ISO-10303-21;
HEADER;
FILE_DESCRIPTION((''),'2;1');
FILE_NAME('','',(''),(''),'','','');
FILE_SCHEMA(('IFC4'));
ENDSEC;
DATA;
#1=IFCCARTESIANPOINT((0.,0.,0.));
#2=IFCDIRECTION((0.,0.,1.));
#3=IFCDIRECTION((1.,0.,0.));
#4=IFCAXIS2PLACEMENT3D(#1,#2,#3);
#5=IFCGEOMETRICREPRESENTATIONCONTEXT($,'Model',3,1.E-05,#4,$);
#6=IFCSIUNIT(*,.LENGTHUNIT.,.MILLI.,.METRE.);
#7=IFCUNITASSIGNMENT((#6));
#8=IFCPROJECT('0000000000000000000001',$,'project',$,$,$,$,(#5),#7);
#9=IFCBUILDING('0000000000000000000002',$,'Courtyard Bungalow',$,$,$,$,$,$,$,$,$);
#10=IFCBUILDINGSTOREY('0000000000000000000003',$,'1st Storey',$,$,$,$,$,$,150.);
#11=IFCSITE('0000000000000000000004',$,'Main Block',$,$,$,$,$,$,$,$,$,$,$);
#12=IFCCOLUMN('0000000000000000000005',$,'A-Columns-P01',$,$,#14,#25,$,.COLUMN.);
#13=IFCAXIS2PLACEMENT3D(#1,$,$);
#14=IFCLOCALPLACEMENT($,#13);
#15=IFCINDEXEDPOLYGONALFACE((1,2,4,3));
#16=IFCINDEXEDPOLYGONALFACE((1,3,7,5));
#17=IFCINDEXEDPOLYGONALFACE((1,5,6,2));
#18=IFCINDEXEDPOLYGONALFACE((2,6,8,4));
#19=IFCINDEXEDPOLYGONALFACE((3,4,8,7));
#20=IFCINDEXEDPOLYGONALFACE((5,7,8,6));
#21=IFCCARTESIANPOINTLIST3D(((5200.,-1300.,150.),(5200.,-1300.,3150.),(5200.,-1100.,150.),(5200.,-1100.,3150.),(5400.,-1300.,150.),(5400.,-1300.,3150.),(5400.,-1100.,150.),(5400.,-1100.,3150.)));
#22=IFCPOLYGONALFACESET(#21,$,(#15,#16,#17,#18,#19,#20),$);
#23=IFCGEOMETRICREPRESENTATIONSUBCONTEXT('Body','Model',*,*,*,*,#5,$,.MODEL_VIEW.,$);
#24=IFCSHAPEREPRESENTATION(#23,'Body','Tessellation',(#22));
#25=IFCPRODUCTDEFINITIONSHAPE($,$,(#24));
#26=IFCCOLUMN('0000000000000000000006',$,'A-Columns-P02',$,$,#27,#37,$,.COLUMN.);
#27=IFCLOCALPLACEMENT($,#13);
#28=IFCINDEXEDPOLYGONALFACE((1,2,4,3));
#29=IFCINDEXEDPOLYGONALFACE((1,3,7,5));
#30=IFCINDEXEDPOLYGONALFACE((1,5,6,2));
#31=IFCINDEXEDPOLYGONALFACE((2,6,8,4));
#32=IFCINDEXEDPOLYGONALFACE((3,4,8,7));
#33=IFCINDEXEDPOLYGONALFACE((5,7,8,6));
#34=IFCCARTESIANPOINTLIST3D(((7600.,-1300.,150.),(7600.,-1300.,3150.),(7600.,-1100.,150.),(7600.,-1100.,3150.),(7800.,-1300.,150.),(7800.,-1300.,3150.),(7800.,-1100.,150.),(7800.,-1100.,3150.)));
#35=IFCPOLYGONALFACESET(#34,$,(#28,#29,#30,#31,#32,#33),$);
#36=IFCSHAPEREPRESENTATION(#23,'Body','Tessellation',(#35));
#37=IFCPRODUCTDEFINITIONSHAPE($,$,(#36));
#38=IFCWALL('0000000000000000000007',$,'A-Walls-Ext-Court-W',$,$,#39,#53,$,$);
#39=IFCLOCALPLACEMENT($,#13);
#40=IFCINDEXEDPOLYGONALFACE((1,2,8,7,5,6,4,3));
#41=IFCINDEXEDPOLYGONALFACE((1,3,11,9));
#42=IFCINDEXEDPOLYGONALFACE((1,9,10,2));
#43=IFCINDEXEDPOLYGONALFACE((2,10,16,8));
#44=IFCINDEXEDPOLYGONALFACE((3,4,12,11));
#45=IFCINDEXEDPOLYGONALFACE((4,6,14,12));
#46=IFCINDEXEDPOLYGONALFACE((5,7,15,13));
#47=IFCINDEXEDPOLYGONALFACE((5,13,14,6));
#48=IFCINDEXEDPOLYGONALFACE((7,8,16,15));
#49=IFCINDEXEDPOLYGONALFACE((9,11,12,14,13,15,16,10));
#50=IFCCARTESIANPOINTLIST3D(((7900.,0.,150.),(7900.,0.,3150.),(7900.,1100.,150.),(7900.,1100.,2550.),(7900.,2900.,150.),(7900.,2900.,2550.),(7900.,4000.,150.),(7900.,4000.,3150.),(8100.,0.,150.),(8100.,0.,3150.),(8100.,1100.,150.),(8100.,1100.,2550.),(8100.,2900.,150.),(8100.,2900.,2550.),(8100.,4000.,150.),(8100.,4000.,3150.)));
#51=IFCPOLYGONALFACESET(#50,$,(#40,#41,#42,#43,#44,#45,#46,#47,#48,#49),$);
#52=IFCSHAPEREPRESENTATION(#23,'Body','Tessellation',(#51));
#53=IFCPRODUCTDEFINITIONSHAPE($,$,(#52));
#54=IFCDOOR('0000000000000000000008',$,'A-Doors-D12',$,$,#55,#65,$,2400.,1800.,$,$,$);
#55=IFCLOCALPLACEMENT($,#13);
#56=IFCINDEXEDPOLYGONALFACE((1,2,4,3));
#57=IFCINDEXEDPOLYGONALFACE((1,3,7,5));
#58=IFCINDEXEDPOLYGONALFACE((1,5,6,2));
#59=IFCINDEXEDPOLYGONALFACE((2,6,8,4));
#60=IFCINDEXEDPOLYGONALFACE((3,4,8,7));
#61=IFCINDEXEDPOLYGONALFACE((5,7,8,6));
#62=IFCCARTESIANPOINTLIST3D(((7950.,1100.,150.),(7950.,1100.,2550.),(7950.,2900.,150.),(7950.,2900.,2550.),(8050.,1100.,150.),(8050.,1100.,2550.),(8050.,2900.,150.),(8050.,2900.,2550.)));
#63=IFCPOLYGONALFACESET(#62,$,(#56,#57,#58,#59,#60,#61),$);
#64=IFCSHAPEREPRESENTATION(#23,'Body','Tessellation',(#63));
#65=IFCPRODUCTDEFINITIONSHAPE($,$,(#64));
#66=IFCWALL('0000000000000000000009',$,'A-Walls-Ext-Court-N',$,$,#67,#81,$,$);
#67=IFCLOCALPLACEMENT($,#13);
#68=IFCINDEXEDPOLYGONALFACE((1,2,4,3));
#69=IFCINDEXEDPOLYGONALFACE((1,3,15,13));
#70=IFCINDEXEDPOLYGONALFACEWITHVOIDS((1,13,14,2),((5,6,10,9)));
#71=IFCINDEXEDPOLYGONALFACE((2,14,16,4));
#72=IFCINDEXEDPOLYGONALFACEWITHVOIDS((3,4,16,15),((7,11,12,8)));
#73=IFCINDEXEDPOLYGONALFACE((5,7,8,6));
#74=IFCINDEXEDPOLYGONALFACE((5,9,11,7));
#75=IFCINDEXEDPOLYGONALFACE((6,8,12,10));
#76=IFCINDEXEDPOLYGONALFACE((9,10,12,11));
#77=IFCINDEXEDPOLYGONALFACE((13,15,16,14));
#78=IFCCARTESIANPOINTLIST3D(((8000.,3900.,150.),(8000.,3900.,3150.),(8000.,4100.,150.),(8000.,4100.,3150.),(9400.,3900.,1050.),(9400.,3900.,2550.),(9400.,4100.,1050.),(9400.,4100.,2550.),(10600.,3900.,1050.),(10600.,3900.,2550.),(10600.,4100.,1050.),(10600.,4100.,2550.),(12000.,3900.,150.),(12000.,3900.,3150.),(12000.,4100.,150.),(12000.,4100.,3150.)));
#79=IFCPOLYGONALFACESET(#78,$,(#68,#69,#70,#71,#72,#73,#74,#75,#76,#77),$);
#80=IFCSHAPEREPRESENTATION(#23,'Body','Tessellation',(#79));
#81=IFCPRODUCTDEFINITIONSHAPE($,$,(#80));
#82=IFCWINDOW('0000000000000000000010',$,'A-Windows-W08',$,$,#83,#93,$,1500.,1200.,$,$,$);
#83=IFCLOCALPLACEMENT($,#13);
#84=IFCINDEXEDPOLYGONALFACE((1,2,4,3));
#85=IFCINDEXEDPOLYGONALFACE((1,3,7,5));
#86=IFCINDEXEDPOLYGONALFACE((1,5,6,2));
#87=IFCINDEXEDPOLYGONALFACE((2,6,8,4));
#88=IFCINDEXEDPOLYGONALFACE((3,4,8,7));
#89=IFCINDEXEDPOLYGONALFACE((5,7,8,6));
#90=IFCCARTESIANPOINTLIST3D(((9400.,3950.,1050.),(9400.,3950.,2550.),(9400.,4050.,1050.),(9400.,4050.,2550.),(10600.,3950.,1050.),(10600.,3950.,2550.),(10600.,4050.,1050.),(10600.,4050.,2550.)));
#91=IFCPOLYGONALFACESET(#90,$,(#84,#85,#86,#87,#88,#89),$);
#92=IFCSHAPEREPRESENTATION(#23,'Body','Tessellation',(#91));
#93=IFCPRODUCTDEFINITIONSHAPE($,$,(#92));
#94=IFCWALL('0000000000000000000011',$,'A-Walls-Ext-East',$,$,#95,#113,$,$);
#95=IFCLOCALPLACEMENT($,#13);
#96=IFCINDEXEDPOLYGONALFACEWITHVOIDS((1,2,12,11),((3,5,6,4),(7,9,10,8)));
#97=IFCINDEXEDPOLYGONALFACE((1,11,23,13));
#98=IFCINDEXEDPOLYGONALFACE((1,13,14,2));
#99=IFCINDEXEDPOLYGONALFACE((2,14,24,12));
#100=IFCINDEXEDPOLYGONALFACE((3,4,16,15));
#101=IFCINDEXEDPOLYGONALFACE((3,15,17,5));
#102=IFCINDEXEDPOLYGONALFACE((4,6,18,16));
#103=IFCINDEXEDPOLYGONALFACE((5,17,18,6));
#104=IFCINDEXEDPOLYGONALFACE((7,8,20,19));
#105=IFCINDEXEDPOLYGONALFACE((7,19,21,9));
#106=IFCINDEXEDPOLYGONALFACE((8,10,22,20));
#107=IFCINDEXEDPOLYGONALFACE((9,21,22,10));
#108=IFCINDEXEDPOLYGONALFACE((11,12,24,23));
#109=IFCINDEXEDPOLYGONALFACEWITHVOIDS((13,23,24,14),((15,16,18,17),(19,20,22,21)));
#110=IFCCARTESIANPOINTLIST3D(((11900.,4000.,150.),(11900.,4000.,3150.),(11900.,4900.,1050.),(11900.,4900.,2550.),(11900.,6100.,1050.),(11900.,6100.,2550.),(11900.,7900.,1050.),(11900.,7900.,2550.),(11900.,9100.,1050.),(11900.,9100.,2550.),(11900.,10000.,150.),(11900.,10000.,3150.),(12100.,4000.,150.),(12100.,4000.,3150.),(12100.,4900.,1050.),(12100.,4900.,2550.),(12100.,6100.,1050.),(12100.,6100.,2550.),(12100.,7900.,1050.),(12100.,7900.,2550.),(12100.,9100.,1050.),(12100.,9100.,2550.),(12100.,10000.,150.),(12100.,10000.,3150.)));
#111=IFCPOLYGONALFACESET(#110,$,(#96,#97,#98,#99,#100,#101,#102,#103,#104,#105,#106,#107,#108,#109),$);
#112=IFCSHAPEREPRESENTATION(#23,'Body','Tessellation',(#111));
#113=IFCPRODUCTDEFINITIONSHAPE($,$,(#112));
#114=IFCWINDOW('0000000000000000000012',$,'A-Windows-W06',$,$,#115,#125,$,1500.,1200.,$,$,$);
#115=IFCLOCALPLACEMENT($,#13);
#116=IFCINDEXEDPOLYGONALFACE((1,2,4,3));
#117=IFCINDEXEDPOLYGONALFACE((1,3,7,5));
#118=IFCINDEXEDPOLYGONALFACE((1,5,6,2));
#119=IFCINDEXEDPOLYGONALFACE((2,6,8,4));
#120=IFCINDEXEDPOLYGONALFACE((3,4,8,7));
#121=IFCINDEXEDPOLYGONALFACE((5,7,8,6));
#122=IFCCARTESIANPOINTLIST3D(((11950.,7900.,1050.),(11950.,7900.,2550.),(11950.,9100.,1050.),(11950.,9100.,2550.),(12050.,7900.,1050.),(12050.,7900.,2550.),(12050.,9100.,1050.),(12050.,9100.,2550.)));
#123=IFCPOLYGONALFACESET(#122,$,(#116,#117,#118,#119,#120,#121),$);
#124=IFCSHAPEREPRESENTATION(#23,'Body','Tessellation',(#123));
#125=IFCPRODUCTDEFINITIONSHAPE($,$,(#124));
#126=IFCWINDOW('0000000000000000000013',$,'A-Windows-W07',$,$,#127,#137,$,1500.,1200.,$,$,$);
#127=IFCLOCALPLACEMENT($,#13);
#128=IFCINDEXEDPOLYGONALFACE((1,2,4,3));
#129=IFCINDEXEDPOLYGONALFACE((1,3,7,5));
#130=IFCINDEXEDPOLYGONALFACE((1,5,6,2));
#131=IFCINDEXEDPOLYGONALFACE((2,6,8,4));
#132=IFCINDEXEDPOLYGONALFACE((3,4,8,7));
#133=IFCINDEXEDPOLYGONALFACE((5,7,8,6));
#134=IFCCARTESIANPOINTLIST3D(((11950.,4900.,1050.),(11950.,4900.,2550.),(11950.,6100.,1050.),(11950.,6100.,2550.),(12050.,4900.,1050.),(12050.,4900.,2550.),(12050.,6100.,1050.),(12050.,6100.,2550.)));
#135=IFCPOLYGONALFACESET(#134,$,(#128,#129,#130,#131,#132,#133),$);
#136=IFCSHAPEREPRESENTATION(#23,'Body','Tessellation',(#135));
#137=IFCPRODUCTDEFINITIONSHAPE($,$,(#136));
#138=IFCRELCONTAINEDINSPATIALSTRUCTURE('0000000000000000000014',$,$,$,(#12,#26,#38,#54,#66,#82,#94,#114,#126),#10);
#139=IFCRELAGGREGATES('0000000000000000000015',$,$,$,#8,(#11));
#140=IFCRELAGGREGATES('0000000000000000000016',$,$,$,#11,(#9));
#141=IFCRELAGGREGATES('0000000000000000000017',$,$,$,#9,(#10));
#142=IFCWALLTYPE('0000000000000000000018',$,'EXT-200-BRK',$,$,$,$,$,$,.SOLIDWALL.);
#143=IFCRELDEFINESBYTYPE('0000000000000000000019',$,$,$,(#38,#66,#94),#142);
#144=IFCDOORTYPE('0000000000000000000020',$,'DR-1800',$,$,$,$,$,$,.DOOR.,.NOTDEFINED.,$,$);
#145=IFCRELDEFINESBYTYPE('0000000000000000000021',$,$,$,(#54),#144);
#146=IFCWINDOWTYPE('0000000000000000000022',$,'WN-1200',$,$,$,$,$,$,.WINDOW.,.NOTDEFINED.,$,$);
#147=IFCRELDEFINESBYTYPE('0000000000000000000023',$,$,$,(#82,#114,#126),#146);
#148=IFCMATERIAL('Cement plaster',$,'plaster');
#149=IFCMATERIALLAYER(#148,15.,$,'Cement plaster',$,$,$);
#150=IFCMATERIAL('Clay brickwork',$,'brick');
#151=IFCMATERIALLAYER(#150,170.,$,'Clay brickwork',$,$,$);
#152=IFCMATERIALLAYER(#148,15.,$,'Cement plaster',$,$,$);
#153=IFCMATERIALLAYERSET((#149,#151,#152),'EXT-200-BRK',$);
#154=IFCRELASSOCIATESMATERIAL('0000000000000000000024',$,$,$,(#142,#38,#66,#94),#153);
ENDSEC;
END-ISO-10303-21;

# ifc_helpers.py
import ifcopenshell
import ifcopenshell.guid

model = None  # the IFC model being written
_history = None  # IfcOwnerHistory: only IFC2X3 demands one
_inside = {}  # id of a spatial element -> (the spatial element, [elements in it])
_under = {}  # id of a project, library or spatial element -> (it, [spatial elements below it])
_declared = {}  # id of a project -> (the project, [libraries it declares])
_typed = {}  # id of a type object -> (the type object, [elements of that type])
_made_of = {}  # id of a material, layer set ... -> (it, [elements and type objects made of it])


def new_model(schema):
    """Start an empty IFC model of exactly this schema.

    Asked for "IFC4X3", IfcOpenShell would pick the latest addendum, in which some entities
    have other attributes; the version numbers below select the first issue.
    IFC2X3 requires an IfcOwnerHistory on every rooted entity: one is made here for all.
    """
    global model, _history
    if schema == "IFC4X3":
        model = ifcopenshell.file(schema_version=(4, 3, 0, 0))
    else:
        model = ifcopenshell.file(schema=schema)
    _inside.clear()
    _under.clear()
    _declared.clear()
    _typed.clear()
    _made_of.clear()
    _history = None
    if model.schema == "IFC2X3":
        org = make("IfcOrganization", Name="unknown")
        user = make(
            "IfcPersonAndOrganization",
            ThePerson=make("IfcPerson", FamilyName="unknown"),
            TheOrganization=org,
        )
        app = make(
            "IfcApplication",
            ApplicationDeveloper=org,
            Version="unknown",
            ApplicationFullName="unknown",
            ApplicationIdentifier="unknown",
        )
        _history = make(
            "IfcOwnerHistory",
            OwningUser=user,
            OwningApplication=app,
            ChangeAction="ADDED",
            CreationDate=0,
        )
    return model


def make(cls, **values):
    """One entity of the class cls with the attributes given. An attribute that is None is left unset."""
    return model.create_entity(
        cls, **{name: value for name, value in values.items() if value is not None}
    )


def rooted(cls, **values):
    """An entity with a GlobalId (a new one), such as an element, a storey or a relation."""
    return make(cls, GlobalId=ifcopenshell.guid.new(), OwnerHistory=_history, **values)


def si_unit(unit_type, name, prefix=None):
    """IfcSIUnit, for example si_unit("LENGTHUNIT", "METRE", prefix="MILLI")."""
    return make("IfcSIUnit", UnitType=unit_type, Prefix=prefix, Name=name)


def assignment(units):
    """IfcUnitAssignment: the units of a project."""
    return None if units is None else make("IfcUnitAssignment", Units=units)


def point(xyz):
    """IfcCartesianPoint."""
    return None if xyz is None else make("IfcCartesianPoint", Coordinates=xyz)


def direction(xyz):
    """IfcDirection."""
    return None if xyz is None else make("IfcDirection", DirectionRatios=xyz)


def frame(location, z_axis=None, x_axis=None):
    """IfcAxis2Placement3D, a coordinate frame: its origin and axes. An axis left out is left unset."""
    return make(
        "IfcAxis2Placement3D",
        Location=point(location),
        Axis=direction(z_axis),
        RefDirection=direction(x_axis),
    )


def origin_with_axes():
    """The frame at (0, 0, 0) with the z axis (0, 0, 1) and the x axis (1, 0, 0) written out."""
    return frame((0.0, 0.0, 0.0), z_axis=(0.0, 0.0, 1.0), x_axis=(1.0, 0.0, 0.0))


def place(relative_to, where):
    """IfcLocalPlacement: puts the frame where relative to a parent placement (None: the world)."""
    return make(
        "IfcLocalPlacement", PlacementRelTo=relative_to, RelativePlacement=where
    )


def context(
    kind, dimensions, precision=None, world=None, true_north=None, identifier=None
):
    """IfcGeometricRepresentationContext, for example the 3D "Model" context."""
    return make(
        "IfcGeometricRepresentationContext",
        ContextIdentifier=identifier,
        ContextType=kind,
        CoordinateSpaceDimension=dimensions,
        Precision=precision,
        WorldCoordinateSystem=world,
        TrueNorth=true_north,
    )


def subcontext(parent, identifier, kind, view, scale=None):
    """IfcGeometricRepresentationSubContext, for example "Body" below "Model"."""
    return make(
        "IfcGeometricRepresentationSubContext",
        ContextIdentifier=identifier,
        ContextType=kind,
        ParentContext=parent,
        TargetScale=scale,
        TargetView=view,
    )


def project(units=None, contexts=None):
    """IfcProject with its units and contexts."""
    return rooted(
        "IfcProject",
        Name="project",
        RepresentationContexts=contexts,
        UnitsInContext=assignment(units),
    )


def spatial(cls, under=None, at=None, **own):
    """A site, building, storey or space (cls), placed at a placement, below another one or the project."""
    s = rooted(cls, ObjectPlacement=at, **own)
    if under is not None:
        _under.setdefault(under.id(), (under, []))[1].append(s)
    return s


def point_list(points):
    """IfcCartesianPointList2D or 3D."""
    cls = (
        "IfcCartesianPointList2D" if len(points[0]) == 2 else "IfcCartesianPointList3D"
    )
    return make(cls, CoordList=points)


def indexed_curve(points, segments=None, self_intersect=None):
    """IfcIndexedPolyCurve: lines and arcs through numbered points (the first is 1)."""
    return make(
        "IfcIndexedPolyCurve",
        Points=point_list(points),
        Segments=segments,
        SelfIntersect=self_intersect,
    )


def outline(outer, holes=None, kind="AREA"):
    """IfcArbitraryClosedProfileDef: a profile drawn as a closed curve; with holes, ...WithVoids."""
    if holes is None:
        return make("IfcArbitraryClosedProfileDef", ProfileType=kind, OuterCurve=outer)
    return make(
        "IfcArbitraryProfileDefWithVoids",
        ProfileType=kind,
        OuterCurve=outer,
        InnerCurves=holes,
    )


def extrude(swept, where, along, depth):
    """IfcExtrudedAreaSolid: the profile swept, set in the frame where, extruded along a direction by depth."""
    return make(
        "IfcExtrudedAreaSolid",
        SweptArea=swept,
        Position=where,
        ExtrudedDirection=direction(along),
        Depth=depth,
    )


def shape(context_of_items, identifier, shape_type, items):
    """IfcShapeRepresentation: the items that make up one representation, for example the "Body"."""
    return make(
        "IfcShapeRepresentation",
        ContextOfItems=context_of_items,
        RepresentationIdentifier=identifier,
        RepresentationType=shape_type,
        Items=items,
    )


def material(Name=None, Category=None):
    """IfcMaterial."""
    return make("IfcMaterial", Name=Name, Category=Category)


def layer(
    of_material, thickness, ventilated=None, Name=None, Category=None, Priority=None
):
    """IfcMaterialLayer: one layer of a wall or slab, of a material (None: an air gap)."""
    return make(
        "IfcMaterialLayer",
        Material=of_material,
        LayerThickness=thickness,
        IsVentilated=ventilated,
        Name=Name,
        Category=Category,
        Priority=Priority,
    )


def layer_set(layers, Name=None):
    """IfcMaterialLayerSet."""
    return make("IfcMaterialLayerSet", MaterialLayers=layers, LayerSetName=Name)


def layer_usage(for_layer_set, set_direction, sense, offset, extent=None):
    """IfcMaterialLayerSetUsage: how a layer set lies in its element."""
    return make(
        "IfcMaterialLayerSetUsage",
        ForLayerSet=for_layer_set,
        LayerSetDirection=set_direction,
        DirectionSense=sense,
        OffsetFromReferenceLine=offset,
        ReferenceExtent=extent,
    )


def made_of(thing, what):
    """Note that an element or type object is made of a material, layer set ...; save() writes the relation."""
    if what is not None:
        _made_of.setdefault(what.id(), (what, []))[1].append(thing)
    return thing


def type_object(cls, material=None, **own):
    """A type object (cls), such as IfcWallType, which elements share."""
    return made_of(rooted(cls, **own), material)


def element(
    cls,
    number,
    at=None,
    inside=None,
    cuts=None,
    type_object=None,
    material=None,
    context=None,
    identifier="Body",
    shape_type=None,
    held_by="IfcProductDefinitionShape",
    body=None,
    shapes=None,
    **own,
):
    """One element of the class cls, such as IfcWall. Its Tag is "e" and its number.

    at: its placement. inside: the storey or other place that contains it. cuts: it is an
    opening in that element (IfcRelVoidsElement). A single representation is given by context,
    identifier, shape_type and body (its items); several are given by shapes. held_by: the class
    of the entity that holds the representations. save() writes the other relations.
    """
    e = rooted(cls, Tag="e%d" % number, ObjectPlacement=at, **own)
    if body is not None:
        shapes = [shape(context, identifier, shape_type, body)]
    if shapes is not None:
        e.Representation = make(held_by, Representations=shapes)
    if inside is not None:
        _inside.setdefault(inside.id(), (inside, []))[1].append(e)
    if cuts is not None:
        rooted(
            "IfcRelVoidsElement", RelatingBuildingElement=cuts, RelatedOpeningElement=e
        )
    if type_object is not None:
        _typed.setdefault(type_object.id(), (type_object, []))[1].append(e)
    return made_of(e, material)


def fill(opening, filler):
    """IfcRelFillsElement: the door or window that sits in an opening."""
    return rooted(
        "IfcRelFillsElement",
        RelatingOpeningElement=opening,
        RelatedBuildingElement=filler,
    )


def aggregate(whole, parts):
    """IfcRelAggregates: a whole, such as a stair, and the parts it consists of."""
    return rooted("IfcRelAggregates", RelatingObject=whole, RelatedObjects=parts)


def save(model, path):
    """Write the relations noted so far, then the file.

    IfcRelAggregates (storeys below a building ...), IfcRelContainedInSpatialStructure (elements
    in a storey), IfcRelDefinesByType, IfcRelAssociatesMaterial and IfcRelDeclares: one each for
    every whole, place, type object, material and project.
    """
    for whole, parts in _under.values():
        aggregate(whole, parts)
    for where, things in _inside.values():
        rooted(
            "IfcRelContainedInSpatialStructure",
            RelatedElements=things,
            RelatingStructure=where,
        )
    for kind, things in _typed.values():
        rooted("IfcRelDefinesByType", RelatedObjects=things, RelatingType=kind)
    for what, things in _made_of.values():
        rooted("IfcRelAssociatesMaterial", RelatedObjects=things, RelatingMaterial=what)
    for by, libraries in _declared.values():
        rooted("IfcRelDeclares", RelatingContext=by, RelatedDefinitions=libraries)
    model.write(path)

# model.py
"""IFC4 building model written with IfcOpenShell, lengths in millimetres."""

from ifc_helpers import new_model, si_unit, frame, origin_with_axes, place, context, subcontext, project, spatial, indexed_curve, outline, extrude, material, layer, layer_set, layer_usage, type_object, element, fill, save


model = new_model("IFC4")

# Units and contexts
model_context = context("Model", 3, precision=1e-05, world=origin_with_axes())
body_context = subcontext(model_context, "Body", "Model", "MODEL_VIEW")
ifc_project = project(units=[si_unit("LENGTHUNIT", "METRE", prefix="MILLI")], contexts=[model_context])

# Site, building, storey
site = spatial("IfcSite", under=ifc_project, Name="Main Block")
building = spatial("IfcBuilding", under=site, Name="Courtyard Bungalow")
storey = spatial("IfcBuildingStorey", under=building, Name="1st Storey", Elevation=150.0)

# Columns
for number, where, z_axis, x_axis, name in (
    (1, (5300.0, -1200.0, 150.0), (0.0, 0.0, 1.0), (1.0, 0.0, 0.0), "A-Columns-P01"),
    (2, (7700.0, -1200.0, 150.0), (0.0, 0.0, 1.0), (1.0, 0.0, 0.0), "A-Columns-P02"),
):
    element("IfcColumn", number, at=place(None, frame(where, z_axis=z_axis, x_axis=x_axis)), inside=storey, Name=name, PredefinedType="COLUMN", context=body_context, shape_type="SweptSolid", body=[
        extrude(outline(indexed_curve([(-100.0, -100.0), (100.0, -100.0), (100.0, 100.0), (-100.0, 100.0)])), None, (0.0, 0.0, 1.0), 3000.0),
    ])

# Wall, opening, door
ifc_material_1 = material(Name="Cement plaster", Category="plaster")
ifc_layer_1 = layer(ifc_material_1, 15.0, Name="Cement plaster")
ifc_material_2 = material(Name="Clay brickwork", Category="brick")
ifc_layer_2 = layer(ifc_material_2, 170.0, Name="Clay brickwork")
ifc_layer_3 = layer(ifc_material_1, 15.0, Name="Cement plaster")
ifc_layer_set_1 = layer_set([ifc_layer_1, ifc_layer_2, ifc_layer_3], Name="EXT-200-BRK")
ifc_layer_usage_1 = layer_usage(ifc_layer_set_1, "AXIS2", "POSITIVE", 0.0)
wall_type_1 = type_object("IfcWallType", Name="EXT-200-BRK", PredefinedType="SOLIDWALL", material=ifc_layer_set_1)
wall_1_placement = place(None, frame((8100.0, 0.0, 150.0), z_axis=(0.0, 0.0, 1.0), x_axis=(0.0, 1.0, 0.0)))
wall_1 = element("IfcWall", 3, at=wall_1_placement, inside=storey, type_object=wall_type_1, material=ifc_layer_usage_1, Name="A-Walls-Ext-Court-W", context=body_context, shape_type="SweptSolid", body=[
    extrude(outline(indexed_curve([(0.0, 0.0), (0.0, 200.0), (4000.0, 200.0), (4000.0, 0.0), (0.0, 0.0)], self_intersect=False)), origin_with_axes(), (0.0, 0.0, 1.0), 3000.0),
])
opening_1_placement = place(wall_1_placement, frame((2000.0, 100.0, 0.0), z_axis=(0.0, 0.0, 1.0), x_axis=(1.0, 0.0, 0.0)))
opening_1 = element("IfcOpeningElement", 4, at=opening_1_placement, cuts=wall_1, PredefinedType="OPENING", context=body_context, shape_type="SweptSolid", body=[
    extrude(outline(indexed_curve([(-900.0, -150.0), (900.0, -150.0), (900.0, 150.0), (-900.0, 150.0)])), None, (0.0, 0.0, 1.0), 2400.0),
])
door_type_1 = type_object("IfcDoorType", Name="DR-1800", OperationType="NOTDEFINED", PredefinedType="DOOR")
door_1_placement = place(None, frame((8000.0, 2000.0, 150.0), z_axis=(0.0, 0.0, 1.0), x_axis=(0.0, 1.0, 0.0)))
door_1 = element("IfcDoor", 5, at=door_1_placement, inside=storey, type_object=door_type_1, Name="A-Doors-D12", OverallHeight=2400.0, OverallWidth=1800.0, context=body_context, shape_type="SweptSolid", body=[
    extrude(outline(indexed_curve([(-900.0, -50.0), (900.0, -50.0), (900.0, 50.0), (-900.0, 50.0)])), None, (0.0, 0.0, 1.0), 2400.0),
])
fill(opening_1, door_1)

# Wall, opening, window
ifc_layer_usage_2 = layer_usage(ifc_layer_set_1, "AXIS2", "POSITIVE", 0.0)
wall_2_placement = place(None, frame((8000.0, 3900.0, 150.0), z_axis=(0.0, 0.0, 1.0), x_axis=(1.0, 0.0, 0.0)))
wall_2 = element("IfcWall", 6, at=wall_2_placement, inside=storey, type_object=wall_type_1, material=ifc_layer_usage_2, Name="A-Walls-Ext-Court-N", context=body_context, shape_type="SweptSolid", body=[
    extrude(outline(indexed_curve([(0.0, 0.0), (0.0, 200.0), (4000.0, 200.0), (4000.0, 0.0), (0.0, 0.0)], self_intersect=False)), origin_with_axes(), (0.0, 0.0, 1.0), 3000.0),
])
opening_2_placement = place(wall_2_placement, frame((2000.0, 100.0, 900.0), z_axis=(0.0, 0.0, 1.0), x_axis=(1.0, 0.0, 0.0)))
opening_2 = element("IfcOpeningElement", 7, at=opening_2_placement, cuts=wall_2, PredefinedType="OPENING", context=body_context, shape_type="SweptSolid", body=[
    extrude(outline(indexed_curve([(-600.0, -150.0), (600.0, -150.0), (600.0, 150.0), (-600.0, 150.0)])), None, (0.0, 0.0, 1.0), 1500.0),
])
window_type_1 = type_object("IfcWindowType", Name="WN-1200", PartitioningType="NOTDEFINED", PredefinedType="WINDOW")
window_1_placement = place(None, frame((10000.0, 4000.0, 1050.0), z_axis=(0.0, 0.0, 1.0), x_axis=(1.0, 0.0, 0.0)))
window_1 = element("IfcWindow", 8, at=window_1_placement, inside=storey, type_object=window_type_1, Name="A-Windows-W08", OverallHeight=1500.0, OverallWidth=1200.0, context=body_context, shape_type="SweptSolid", body=[
    extrude(outline(indexed_curve([(-600.0, -50.0), (600.0, -50.0), (600.0, 50.0), (-600.0, 50.0)])), None, (0.0, 0.0, 1.0), 1500.0),
])
fill(opening_2, window_1)

# Wall, openings, windows
ifc_layer_usage_3 = layer_usage(ifc_layer_set_1, "AXIS2", "POSITIVE", 0.0)
wall_3_placement = place(None, frame((12100.0, 4000.0, 150.0), z_axis=(0.0, 0.0, 1.0), x_axis=(0.0, 1.0, 0.0)))
wall_3 = element("IfcWall", 9, at=wall_3_placement, inside=storey, type_object=wall_type_1, material=ifc_layer_usage_3, Name="A-Walls-Ext-East", context=body_context, shape_type="SweptSolid", body=[
    extrude(outline(indexed_curve([(0.0, 0.0), (0.0, 200.0), (6000.0, 200.0), (6000.0, 0.0), (0.0, 0.0)], self_intersect=False)), origin_with_axes(), (0.0, 0.0, 1.0), 3000.0),
])
opening_3_placement = place(wall_3_placement, frame((4500.0, 100.0, 900.0), z_axis=(0.0, 0.0, 1.0), x_axis=(1.0, 0.0, 0.0)))
opening_3 = element("IfcOpeningElement", 10, at=opening_3_placement, cuts=wall_3, PredefinedType="OPENING", context=body_context, shape_type="SweptSolid", body=[
    extrude(outline(indexed_curve([(-600.0, -150.0), (600.0, -150.0), (600.0, 150.0), (-600.0, 150.0)])), None, (0.0, 0.0, 1.0), 1500.0),
])
opening_4_placement = place(wall_3_placement, frame((1500.0, 100.0, 900.0), z_axis=(0.0, 0.0, 1.0), x_axis=(1.0, 0.0, 0.0)))
opening_4 = element("IfcOpeningElement", 11, at=opening_4_placement, cuts=wall_3, PredefinedType="OPENING", context=body_context, shape_type="SweptSolid", body=[
    extrude(outline(indexed_curve([(-600.0, -150.0), (600.0, -150.0), (600.0, 150.0), (-600.0, 150.0)])), None, (0.0, 0.0, 1.0), 1500.0),
])
window_2_placement = place(None, frame((12000.0, 8500.0, 1050.0), z_axis=(0.0, 0.0, 1.0), x_axis=(0.0, 1.0, 0.0)))
window_2 = element("IfcWindow", 12, at=window_2_placement, inside=storey, type_object=window_type_1, Name="A-Windows-W06", OverallHeight=1500.0, OverallWidth=1200.0, context=body_context, shape_type="SweptSolid", body=[
    extrude(outline(indexed_curve([(-600.0, -50.0), (600.0, -50.0), (600.0, 50.0), (-600.0, 50.0)])), None, (0.0, 0.0, 1.0), 1500.0),
])
fill(opening_3, window_2)
window_3_placement = place(None, frame((12000.0, 5500.0, 1050.0), z_axis=(0.0, 0.0, 1.0), x_axis=(0.0, 1.0, 0.0)))
window_3 = element("IfcWindow", 13, at=window_3_placement, inside=storey, type_object=window_type_1, Name="A-Windows-W07", OverallHeight=1500.0, OverallWidth=1200.0, context=body_context, shape_type="SweptSolid", body=[
    extrude(outline(indexed_curve([(-600.0, -50.0), (600.0, -50.0), (600.0, 50.0), (-600.0, 50.0)])), None, (0.0, 0.0, 1.0), 1500.0),
])
fill(opening_4, window_3)

save(model, "model.ifc")
